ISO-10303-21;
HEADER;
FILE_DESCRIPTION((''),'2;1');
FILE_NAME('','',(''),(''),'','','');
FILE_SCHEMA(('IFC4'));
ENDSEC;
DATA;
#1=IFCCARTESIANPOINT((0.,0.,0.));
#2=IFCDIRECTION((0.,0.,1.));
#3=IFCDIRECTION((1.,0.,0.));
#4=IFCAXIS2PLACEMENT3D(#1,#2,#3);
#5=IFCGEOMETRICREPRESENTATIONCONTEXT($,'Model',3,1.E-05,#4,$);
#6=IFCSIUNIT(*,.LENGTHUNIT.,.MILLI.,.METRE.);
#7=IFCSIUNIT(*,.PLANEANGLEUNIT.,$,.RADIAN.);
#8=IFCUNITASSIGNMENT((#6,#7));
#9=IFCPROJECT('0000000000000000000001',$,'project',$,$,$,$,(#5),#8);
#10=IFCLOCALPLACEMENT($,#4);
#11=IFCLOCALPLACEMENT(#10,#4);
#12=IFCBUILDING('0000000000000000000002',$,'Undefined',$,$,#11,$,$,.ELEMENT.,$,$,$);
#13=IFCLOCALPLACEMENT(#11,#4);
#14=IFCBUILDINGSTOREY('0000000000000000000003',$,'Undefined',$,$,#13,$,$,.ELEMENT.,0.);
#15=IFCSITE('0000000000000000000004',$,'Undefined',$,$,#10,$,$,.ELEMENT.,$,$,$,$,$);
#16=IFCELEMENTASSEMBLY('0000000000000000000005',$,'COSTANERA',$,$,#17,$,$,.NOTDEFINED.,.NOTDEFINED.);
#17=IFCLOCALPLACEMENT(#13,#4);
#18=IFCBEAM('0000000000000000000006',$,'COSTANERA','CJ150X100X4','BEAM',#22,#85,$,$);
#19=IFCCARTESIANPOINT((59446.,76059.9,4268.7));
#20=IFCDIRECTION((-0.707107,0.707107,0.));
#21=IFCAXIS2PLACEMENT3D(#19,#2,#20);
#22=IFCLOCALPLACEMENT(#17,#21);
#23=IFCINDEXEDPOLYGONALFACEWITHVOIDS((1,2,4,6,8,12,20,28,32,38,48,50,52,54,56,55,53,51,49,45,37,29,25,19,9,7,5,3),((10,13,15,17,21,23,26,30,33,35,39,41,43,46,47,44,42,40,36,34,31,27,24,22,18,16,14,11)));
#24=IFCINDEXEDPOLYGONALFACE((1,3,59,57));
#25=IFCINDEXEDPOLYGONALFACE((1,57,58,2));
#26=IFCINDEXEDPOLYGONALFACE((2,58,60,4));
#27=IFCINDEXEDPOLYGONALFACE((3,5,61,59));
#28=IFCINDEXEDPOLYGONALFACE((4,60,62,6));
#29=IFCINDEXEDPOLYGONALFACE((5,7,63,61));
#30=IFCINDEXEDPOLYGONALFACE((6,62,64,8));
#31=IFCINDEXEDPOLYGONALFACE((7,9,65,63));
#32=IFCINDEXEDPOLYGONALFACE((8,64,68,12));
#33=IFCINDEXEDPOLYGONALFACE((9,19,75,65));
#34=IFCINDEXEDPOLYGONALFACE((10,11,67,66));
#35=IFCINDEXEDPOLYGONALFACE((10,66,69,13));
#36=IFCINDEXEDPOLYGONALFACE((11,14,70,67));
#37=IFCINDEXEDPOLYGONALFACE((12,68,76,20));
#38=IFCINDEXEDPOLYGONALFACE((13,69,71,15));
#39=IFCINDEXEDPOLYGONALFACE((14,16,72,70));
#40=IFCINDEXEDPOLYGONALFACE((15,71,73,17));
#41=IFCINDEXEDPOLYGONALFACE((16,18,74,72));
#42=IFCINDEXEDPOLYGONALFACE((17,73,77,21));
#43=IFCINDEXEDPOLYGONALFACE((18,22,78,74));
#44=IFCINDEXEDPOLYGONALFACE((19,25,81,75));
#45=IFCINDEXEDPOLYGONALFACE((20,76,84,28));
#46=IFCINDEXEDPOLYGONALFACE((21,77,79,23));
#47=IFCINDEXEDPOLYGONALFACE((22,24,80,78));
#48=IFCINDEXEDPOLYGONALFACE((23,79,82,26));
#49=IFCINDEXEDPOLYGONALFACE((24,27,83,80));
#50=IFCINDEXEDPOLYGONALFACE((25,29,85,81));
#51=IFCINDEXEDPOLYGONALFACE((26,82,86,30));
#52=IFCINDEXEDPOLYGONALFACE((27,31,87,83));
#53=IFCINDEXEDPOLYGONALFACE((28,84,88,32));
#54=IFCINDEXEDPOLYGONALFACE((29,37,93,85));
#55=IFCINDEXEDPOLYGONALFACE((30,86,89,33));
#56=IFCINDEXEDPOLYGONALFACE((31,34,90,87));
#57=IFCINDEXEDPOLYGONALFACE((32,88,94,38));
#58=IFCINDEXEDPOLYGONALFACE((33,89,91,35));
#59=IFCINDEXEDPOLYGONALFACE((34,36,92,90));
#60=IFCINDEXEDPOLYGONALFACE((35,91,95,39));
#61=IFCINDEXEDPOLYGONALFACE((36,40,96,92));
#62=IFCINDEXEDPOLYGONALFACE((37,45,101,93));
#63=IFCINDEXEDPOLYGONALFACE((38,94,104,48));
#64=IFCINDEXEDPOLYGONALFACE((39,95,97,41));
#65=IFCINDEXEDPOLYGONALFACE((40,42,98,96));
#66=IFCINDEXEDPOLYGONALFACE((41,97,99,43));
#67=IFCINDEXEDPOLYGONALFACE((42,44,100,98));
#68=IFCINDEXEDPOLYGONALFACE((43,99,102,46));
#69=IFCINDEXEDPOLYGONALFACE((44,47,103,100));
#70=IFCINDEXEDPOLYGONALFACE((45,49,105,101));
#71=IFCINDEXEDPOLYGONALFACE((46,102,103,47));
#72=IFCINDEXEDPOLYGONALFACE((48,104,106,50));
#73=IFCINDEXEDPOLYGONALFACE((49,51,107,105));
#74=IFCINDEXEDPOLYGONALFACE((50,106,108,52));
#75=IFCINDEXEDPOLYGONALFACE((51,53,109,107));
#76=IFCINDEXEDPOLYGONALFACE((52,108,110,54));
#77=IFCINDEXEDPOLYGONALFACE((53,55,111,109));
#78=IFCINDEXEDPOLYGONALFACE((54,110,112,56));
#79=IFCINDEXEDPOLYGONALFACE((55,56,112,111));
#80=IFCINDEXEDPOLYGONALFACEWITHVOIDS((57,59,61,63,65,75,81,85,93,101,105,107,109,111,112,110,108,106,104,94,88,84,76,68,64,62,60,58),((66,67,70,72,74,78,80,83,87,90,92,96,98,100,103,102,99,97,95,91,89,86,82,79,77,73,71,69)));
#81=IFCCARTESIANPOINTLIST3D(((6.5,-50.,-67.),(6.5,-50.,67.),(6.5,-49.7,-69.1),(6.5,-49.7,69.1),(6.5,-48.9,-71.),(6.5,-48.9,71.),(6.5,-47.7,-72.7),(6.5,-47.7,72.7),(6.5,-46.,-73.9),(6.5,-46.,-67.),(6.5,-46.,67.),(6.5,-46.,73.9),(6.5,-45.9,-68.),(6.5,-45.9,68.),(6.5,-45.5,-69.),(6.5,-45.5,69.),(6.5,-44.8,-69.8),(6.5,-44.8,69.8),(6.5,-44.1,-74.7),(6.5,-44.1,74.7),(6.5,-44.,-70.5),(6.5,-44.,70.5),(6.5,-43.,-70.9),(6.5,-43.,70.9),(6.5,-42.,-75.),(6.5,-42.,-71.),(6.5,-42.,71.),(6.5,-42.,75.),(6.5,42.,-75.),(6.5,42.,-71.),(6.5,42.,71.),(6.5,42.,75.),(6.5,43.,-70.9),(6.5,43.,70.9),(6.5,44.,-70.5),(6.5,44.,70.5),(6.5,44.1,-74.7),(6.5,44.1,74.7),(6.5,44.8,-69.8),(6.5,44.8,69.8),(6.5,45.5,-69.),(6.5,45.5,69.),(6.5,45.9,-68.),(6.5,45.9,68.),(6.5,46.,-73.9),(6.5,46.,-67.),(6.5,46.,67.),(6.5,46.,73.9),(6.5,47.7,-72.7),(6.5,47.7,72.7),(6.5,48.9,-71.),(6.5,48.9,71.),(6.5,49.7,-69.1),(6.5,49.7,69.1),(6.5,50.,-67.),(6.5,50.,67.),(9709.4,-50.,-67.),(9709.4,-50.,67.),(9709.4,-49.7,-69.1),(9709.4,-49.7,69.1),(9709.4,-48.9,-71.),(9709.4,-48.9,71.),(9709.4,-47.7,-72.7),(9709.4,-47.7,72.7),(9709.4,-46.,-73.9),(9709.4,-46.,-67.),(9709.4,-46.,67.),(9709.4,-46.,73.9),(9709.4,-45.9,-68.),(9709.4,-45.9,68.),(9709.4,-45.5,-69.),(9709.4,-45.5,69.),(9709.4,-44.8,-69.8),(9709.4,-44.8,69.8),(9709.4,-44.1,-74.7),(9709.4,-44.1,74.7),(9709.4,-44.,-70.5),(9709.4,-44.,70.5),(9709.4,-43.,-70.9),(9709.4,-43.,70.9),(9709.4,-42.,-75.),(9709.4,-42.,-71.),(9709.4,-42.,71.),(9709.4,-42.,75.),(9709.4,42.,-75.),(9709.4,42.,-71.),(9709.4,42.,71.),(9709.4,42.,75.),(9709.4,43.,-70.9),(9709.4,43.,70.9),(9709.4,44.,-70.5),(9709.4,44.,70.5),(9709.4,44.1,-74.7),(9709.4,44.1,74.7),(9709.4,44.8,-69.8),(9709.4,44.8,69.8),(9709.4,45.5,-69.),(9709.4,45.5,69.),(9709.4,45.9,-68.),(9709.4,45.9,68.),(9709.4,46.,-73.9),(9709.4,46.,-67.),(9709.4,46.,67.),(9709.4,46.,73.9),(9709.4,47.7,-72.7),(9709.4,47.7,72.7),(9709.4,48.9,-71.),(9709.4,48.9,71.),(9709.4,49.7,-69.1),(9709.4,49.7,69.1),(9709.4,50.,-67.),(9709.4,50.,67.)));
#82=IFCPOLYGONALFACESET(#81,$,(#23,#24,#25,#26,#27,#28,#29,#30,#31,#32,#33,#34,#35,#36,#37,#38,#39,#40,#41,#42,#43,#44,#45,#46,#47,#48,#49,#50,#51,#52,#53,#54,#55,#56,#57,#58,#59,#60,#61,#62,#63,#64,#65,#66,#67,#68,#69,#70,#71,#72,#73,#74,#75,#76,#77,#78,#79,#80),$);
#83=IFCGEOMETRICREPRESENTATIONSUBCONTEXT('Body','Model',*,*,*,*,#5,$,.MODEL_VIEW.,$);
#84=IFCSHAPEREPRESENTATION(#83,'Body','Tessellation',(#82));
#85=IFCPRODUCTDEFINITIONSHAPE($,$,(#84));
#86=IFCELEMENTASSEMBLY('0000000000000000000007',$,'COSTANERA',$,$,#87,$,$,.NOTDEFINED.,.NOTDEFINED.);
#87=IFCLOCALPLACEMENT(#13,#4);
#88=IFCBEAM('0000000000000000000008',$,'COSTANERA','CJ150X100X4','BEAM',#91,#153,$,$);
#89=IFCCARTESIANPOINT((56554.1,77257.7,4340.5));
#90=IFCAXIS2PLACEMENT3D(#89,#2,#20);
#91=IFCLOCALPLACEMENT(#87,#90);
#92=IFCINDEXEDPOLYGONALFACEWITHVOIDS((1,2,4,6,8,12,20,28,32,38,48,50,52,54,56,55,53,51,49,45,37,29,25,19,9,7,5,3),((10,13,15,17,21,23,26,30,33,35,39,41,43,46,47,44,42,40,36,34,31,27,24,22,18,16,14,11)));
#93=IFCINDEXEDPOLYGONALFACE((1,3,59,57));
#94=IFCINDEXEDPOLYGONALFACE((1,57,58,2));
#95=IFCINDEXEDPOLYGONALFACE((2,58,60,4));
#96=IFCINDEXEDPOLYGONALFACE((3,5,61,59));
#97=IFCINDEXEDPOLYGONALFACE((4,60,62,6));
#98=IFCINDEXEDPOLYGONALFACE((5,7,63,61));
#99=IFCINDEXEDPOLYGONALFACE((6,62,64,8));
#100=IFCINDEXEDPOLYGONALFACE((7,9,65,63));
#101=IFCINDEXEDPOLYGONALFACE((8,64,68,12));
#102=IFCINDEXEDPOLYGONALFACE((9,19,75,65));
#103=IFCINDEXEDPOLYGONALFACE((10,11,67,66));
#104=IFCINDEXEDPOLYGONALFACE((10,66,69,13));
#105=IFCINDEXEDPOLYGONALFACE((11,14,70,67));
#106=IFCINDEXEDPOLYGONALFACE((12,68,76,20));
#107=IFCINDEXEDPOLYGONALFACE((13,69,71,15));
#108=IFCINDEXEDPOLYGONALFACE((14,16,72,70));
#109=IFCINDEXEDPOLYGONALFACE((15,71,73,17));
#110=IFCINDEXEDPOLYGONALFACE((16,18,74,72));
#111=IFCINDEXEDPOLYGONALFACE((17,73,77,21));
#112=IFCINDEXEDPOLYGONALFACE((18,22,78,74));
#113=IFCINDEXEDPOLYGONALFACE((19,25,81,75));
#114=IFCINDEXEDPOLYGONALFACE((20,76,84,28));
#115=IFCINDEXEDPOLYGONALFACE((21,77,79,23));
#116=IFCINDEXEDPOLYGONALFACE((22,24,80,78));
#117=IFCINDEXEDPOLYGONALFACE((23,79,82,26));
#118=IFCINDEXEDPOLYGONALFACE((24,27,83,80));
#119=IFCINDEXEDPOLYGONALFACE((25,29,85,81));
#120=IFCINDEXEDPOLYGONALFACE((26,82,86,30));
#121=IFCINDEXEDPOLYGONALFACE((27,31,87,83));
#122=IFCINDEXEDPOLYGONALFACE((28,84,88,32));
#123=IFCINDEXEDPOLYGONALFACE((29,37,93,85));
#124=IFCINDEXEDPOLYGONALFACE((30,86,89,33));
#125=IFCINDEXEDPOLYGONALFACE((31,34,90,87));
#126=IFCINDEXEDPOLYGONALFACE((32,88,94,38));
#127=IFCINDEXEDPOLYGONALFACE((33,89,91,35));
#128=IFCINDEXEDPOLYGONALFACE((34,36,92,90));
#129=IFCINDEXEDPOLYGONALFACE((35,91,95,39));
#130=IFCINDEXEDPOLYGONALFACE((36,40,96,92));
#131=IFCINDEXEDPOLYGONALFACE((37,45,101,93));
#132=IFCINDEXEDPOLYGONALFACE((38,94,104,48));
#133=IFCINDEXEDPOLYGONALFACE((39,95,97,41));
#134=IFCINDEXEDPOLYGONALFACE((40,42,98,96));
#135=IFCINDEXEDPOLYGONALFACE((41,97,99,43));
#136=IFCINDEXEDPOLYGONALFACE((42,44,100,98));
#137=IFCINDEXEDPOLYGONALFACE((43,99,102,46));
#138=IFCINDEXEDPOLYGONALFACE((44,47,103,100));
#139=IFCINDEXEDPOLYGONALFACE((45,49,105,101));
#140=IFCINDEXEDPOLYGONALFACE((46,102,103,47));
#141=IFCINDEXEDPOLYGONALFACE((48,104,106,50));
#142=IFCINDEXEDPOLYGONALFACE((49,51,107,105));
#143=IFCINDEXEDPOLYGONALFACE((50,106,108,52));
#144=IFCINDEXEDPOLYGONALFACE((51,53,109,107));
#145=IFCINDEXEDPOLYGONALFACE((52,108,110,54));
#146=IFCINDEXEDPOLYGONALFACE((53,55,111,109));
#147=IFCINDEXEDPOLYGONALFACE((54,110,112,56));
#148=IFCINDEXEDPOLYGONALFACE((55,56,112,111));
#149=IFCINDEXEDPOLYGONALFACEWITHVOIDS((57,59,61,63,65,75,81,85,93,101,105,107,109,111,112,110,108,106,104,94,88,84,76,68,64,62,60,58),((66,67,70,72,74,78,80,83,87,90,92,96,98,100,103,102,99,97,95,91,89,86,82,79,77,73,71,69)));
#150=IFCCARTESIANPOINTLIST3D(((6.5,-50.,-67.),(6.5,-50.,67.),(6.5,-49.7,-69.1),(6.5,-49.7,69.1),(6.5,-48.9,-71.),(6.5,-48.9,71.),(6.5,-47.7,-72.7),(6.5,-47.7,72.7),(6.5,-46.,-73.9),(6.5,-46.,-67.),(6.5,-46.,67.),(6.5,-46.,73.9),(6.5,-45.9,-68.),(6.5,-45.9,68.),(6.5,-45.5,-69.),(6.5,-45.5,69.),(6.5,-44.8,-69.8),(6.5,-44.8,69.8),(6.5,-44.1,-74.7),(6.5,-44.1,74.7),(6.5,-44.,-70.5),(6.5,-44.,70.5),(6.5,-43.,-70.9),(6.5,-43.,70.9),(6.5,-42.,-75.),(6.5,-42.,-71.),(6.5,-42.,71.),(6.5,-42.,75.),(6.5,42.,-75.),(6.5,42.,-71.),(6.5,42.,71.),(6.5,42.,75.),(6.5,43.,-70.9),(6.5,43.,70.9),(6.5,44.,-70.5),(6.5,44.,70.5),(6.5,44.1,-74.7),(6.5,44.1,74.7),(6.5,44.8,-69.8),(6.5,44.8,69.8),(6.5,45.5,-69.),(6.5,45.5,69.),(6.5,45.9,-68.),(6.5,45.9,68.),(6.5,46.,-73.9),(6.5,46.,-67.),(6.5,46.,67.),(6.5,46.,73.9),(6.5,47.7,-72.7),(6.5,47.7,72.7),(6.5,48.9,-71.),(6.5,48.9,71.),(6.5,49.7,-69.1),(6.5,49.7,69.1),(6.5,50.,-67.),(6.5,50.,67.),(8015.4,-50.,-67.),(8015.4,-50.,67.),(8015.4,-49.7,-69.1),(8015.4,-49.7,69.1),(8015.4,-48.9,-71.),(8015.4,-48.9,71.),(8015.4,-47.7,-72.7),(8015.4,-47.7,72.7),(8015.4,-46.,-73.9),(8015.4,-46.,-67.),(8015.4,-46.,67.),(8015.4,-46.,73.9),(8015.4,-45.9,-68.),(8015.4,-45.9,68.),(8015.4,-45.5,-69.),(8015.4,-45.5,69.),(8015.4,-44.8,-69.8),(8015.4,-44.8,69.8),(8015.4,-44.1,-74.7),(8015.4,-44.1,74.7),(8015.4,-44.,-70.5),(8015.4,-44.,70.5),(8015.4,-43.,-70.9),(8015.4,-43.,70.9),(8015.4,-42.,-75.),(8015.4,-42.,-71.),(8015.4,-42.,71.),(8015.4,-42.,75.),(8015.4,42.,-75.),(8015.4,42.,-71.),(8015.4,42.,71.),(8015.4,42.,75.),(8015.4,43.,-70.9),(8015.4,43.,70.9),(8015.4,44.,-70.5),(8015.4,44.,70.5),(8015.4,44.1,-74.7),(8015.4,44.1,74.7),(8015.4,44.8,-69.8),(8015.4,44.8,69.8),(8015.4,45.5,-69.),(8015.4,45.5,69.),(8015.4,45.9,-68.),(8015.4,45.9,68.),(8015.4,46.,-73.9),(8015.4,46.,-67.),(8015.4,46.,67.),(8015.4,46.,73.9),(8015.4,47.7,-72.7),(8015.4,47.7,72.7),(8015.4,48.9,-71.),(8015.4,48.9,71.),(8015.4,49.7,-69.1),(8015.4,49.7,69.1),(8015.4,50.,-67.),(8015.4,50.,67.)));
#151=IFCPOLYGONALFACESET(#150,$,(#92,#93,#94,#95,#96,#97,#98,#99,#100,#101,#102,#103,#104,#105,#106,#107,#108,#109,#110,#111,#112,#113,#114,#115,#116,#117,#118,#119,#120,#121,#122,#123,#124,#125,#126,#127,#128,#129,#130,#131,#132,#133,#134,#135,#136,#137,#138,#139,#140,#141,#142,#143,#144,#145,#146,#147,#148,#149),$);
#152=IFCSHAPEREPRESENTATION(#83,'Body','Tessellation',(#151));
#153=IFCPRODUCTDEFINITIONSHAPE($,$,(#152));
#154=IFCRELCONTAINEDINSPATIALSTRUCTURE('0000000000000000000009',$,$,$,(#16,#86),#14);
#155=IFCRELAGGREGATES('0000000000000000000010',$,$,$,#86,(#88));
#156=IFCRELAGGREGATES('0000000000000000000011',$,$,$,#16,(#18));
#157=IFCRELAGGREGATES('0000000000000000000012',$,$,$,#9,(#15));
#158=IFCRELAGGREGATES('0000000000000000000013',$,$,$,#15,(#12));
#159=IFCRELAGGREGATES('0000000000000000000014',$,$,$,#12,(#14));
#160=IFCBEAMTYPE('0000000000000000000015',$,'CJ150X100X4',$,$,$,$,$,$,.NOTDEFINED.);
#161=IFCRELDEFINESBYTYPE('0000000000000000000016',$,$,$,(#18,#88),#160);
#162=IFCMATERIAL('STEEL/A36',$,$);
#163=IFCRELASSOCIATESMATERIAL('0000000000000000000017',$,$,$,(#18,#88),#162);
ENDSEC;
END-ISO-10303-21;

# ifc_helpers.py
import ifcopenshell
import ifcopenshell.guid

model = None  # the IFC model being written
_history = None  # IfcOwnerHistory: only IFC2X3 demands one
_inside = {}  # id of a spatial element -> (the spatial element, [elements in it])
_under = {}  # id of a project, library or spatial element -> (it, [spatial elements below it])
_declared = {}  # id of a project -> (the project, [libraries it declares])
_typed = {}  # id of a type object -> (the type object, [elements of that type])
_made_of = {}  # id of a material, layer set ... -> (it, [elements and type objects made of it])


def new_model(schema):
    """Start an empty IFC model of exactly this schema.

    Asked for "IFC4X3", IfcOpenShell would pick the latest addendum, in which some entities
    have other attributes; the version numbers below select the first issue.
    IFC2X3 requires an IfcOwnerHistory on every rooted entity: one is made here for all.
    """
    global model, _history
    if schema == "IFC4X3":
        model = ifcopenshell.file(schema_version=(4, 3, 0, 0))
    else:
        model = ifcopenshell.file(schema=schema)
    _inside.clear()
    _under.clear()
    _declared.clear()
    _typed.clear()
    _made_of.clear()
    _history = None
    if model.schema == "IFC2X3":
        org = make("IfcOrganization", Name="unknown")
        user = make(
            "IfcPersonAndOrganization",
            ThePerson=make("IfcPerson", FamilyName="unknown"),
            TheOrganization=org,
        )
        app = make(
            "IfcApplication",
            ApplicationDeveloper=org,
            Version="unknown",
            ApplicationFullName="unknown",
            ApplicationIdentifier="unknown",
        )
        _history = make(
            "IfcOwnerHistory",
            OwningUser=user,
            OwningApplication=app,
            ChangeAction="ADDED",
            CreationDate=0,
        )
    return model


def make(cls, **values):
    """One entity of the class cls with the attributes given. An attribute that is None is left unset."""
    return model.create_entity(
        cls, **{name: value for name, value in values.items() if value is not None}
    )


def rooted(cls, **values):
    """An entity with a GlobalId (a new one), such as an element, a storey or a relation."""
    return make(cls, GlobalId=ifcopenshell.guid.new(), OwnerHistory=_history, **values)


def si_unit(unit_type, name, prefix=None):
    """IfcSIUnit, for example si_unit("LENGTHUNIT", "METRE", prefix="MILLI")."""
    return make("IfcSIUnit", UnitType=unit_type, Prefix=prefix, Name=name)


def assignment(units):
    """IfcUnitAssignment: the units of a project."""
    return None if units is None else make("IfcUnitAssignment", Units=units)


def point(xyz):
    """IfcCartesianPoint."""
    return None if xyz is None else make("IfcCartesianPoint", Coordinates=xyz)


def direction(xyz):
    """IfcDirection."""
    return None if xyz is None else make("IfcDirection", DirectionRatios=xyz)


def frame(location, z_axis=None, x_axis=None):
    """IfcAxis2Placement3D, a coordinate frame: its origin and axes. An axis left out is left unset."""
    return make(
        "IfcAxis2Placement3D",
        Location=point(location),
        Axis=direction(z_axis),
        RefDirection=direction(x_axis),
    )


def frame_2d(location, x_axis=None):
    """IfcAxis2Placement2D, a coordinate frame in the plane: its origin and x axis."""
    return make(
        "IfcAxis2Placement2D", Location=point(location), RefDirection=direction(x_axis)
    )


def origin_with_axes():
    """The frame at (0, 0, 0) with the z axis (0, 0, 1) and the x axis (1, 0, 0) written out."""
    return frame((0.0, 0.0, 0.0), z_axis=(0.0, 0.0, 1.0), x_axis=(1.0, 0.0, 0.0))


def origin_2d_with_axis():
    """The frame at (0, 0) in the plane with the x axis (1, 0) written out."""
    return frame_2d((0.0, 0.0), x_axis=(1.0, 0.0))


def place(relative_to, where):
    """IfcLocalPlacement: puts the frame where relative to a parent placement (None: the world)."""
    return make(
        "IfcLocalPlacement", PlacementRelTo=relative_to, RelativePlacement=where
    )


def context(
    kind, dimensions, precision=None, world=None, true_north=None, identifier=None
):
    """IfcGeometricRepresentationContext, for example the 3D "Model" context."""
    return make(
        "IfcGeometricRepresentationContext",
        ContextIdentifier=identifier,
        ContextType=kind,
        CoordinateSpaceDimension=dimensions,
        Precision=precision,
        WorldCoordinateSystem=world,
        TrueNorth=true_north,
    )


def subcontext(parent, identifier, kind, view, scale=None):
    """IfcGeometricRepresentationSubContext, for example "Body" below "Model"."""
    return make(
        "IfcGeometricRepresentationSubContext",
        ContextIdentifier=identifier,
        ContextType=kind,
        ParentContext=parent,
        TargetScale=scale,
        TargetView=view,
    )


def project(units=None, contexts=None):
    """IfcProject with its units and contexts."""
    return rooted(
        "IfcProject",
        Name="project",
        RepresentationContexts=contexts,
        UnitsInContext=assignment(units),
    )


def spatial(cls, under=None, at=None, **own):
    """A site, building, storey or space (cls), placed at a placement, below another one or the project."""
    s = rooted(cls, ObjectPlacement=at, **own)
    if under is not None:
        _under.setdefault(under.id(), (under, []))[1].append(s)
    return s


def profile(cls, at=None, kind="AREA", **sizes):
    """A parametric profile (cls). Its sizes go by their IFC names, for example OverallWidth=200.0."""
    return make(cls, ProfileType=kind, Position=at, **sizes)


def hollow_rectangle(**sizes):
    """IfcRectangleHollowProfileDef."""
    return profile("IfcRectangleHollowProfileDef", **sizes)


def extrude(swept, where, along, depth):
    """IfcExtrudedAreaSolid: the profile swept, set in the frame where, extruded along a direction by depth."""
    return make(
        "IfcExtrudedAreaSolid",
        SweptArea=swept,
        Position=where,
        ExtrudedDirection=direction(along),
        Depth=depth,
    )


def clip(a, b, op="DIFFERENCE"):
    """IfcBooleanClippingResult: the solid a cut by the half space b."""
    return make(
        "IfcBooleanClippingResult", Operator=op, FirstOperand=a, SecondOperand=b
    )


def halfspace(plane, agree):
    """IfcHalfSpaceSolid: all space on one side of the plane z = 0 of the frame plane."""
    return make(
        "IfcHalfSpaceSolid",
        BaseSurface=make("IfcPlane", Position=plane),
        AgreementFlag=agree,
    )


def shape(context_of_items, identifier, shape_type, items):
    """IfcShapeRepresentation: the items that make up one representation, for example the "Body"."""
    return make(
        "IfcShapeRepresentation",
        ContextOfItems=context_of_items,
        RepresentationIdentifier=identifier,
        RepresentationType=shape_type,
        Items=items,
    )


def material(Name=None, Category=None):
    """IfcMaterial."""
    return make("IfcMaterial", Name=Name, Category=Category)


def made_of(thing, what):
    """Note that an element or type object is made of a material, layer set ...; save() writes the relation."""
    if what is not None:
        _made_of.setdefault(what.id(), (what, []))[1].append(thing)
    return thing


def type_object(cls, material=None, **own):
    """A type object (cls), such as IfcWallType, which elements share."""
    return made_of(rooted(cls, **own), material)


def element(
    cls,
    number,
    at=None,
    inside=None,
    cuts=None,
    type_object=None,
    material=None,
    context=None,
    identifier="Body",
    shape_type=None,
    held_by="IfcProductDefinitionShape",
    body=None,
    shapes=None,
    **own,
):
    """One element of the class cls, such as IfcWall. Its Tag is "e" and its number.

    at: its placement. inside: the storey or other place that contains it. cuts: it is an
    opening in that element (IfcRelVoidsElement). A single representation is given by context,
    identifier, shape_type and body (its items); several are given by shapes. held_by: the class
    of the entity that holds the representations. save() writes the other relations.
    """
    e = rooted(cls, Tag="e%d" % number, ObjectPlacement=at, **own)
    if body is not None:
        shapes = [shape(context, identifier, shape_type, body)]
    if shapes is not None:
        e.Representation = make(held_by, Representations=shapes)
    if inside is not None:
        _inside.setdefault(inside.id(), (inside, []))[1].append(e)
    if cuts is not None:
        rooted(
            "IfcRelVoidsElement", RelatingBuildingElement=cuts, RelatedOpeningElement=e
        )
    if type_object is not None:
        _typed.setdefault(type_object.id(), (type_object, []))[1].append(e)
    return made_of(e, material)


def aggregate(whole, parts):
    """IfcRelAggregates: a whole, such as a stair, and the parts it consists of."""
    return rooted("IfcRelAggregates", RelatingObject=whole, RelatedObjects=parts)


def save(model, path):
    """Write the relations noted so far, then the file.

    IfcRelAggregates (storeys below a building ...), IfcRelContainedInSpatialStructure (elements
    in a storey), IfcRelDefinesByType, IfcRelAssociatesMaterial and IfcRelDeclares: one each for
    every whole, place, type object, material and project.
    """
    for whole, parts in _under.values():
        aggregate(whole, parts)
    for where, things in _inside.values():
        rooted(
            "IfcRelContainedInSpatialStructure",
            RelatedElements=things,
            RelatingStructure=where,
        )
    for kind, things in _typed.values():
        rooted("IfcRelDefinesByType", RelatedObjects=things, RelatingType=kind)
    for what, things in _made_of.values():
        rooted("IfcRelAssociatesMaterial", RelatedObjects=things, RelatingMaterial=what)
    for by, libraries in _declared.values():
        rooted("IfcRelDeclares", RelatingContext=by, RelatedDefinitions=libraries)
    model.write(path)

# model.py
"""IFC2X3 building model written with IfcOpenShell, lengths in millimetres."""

from ifc_helpers import new_model, si_unit, frame, origin_with_axes, origin_2d_with_axis, place, context, subcontext, project, spatial, hollow_rectangle, extrude, clip, halfspace, material, type_object, element, aggregate, save


model = new_model("IFC2X3")

# Units and contexts
model_context = context("Model", 3, precision=1e-05, world=origin_with_axes())
body_context = subcontext(model_context, "Body", "Model", "MODEL_VIEW")
ifc_project = project(units=[si_unit("LENGTHUNIT", "METRE", prefix="MILLI"), si_unit("PLANEANGLEUNIT", "RADIAN")], contexts=[model_context])

# Site, building, storey
site_placement = place(None, origin_with_axes())
site = spatial("IfcSite", under=ifc_project, at=site_placement, Name="Undefined", CompositionType="ELEMENT")
building_placement = place(site_placement, origin_with_axes())
building = spatial("IfcBuilding", under=site, at=building_placement, Name="Undefined", CompositionType="ELEMENT")
storey_placement = place(building_placement, origin_with_axes())
storey = spatial("IfcBuildingStorey", under=building, at=storey_placement, Name="Undefined", CompositionType="ELEMENT", Elevation=0.0)

# Element assemblies, beams
assembly_1_placement = place(storey_placement, origin_with_axes())
assembly_1 = element("IfcElementAssembly", 1, at=assembly_1_placement, inside=storey, Name="COSTANERA", AssemblyPlace="NOTDEFINED", PredefinedType="NOTDEFINED")
ifc_material_1 = material(Name="STEEL/A36")
beam_type_1 = type_object("IfcBeamType", Name="CJ150X100X4", PredefinedType="NOTDEFINED")
beam_1_placement = place(assembly_1_placement, frame((59446.0, 76059.9, 4268.7), z_axis=(0.0, 0.0, 1.0), x_axis=(-0.707107, 0.707107, 0.0)))
beam_1 = element("IfcBeam", 2, at=beam_1_placement, type_object=beam_type_1, material=ifc_material_1, Name="COSTANERA", Description="CJ150X100X4", ObjectType="BEAM", context=body_context, shape_type="Clipping", body=[
    clip(extrude(hollow_rectangle(XDim=100.0, YDim=150.0, WallThickness=4.0, InnerFilletRadius=4.0, OuterFilletRadius=8.0, at=origin_2d_with_axis()), frame((9709.4, 0.0, 0.0), z_axis=(-1.0, 0.0, 0.0), x_axis=(0.0, -1.0, 0.0)), (0.0, 0.0, 1.0), 9803.9), halfspace(frame((6.5, 0.0, -75.0), z_axis=(1.0, 0.0, 0.0), x_axis=(0.0, -1.0, 0.0)), True)),
])
assembly_2_placement = place(storey_placement, origin_with_axes())
assembly_2 = element("IfcElementAssembly", 3, at=assembly_2_placement, inside=storey, Name="COSTANERA", AssemblyPlace="NOTDEFINED", PredefinedType="NOTDEFINED")
beam_2_placement = place(assembly_2_placement, frame((56554.1, 77257.7, 4340.5), z_axis=(0.0, 0.0, 1.0), x_axis=(-0.707107, 0.707107, 0.0)))
beam_2 = element("IfcBeam", 4, at=beam_2_placement, type_object=beam_type_1, material=ifc_material_1, Name="COSTANERA", Description="CJ150X100X4", ObjectType="BEAM", context=body_context, shape_type="Clipping", body=[
    clip(extrude(hollow_rectangle(XDim=100.0, YDim=150.0, WallThickness=4.0, InnerFilletRadius=4.0, OuterFilletRadius=8.0, at=origin_2d_with_axis()), frame((8015.4, 0.0, 0.0), z_axis=(-1.0, 0.0, 0.0), x_axis=(0.0, -1.0, 0.0)), (0.0, 0.0, 1.0), 8109.9), halfspace(frame((6.5, 0.0, -75.0), z_axis=(1.0, 0.0, 0.0), x_axis=(0.0, -1.0, 0.0)), True)),
])

aggregate(assembly_2, [beam_2])
aggregate(assembly_1, [beam_1])

save(model, "model.ifc")
